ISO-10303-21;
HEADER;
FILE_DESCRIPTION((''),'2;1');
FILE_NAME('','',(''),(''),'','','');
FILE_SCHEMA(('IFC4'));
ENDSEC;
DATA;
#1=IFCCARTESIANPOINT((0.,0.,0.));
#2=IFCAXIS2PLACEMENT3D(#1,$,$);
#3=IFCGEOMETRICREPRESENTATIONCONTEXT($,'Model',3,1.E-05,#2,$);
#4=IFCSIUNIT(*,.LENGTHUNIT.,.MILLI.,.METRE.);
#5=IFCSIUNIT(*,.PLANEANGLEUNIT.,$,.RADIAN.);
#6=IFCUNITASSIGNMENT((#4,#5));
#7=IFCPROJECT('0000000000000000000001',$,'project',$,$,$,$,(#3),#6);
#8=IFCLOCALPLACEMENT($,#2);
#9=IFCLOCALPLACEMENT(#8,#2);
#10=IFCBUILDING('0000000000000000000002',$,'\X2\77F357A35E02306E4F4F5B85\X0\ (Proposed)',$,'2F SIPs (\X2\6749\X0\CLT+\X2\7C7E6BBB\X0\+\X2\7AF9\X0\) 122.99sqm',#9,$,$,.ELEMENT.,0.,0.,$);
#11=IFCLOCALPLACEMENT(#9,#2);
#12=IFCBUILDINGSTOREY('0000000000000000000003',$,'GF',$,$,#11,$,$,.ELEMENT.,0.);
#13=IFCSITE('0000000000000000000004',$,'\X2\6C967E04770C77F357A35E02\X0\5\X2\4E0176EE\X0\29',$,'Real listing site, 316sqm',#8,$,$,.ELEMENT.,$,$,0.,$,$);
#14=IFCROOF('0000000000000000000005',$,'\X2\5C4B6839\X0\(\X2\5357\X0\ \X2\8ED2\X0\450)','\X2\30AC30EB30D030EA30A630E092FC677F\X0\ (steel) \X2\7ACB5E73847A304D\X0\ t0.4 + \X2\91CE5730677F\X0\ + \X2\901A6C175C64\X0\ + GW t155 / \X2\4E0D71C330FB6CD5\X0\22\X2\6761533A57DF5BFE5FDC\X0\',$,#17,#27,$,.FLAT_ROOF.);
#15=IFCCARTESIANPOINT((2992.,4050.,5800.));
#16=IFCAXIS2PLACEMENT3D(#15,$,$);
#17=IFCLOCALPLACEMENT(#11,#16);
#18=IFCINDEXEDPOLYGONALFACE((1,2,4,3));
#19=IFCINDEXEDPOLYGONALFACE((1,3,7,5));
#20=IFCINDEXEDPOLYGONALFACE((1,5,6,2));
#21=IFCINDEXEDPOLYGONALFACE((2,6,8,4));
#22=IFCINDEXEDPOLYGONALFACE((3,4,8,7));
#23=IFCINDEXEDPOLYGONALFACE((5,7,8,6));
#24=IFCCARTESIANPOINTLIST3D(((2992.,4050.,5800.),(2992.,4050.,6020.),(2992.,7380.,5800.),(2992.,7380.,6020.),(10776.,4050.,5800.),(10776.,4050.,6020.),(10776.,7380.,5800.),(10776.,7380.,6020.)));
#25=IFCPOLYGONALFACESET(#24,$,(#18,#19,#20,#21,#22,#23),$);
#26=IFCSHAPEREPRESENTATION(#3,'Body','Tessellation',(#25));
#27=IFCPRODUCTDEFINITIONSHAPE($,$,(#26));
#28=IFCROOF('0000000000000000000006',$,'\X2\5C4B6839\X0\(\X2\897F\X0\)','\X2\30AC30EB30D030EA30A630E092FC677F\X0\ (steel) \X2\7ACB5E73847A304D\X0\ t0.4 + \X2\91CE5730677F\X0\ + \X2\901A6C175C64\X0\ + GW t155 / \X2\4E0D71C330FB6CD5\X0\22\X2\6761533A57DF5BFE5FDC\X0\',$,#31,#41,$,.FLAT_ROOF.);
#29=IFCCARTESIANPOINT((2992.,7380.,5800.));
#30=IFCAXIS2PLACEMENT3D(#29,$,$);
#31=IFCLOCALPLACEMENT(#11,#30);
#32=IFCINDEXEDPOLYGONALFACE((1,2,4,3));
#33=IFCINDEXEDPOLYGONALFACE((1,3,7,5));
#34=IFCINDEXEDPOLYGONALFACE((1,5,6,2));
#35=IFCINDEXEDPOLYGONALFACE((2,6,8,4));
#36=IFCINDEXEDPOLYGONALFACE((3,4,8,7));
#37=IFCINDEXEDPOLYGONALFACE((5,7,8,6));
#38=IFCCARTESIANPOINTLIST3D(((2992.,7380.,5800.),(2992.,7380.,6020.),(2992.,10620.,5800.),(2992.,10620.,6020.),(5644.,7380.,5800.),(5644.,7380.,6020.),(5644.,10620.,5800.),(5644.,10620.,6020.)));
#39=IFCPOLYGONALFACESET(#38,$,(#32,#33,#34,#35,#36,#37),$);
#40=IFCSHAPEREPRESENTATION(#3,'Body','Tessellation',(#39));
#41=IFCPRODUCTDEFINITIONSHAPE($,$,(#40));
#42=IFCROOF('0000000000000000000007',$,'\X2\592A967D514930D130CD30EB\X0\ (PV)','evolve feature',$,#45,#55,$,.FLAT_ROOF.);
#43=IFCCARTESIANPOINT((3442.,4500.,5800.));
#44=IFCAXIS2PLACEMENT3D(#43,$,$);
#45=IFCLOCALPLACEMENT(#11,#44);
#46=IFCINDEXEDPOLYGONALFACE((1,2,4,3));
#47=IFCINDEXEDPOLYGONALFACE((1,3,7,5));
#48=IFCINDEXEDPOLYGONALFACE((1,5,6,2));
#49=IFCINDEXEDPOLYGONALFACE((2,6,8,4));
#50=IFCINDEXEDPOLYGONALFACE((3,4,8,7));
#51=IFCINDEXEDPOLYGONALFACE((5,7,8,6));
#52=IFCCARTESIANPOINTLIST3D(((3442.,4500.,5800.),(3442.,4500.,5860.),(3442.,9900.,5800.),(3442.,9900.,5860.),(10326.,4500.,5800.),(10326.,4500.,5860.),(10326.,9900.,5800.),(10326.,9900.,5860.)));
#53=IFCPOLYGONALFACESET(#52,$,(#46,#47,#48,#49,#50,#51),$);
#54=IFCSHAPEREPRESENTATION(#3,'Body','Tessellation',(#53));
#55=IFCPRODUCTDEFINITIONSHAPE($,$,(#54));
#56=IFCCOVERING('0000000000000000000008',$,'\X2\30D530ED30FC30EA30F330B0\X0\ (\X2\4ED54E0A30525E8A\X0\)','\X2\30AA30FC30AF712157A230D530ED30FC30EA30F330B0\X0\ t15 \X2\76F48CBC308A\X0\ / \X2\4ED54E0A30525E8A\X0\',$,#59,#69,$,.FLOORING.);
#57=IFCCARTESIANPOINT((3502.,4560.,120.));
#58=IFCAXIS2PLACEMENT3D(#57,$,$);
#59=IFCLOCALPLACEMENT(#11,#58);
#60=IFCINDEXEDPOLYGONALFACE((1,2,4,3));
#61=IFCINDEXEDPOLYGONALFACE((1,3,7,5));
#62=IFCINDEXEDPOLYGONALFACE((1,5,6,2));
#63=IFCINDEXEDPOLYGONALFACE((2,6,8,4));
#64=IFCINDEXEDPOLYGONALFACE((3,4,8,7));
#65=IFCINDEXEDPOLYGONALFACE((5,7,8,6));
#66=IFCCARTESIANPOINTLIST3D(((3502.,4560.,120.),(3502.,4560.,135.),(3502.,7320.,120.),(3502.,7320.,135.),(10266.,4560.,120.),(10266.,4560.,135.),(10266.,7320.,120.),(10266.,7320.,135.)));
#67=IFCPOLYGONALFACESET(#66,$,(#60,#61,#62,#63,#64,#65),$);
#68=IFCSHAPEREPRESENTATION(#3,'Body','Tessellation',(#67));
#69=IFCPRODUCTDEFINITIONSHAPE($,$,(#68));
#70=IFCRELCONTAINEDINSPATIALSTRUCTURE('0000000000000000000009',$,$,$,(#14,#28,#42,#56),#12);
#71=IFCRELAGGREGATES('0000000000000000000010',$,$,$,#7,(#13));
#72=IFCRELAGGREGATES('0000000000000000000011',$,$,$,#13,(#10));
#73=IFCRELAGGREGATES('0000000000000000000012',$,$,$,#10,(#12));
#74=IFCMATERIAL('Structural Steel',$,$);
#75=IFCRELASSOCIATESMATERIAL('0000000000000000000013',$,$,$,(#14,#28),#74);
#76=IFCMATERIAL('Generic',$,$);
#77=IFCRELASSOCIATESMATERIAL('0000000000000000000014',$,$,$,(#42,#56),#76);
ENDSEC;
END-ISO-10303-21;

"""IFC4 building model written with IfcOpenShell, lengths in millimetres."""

from ifc_helpers import new_model, si_unit, frame, frame_2d, origin, place, context, project, spatial, rectangle, extrude, material, element, save


model = new_model("IFC4")

# Units and contexts
model_context = context("Model", 3, precision=1e-05, world=origin())
ifc_project = project(units=[si_unit("LENGTHUNIT", "METRE", prefix="MILLI"), si_unit("PLANEANGLEUNIT", "RADIAN")], contexts=[model_context])

# Site, building, storey
site_placement = place(None, origin())
site = spatial("IfcSite", under=ifc_project, at=site_placement, Name="沖縄県石垣市5丁目29", ObjectType="Real listing site, 316sqm", CompositionType="ELEMENT", RefElevation=0.0)
building_placement = place(site_placement, origin())
building = spatial("IfcBuilding", under=site, at=building_placement, Name="石垣市の住宅 (Proposed)", ObjectType="2F SIPs (杉CLT+籾殻+竹) 122.99sqm", CompositionType="ELEMENT", ElevationOfRefHeight=0.0, ElevationOfTerrain=0.0)
storey_placement = place(building_placement, origin())
storey = spatial("IfcBuildingStorey", under=building, at=storey_placement, Name="GF", CompositionType="ELEMENT", Elevation=0.0)

# Shared definitions
ifc_material_1 = material(Name="Generic")

# Roofs
ifc_material_2 = material(Name="Structural Steel")
roof_1_placement = place(storey_placement, frame((2992.0, 4050.0, 5800.0)))
element("IfcRoof", 1, at=roof_1_placement, inside=storey, material=ifc_material_2, Name="屋根(南 軒450)", Description="ガルバリウム鋼板 (steel) 立平葺き t0.4 + 野地板 + 通気層 + GW t155 / 不燃・法22条区域対応", PredefinedType="FLAT_ROOF", context=model_context, shape_type="SweptSolid", body=[
    extrude(rectangle(XDim=7784.0, YDim=3330.0, at=frame_2d((3892.0, 1665.0))), frame((2992.0, 4050.0, 5800.0)), (0.0, 0.0, 1.0), 220.0),
])
roof_2_placement = place(storey_placement, frame((2992.0, 7380.0, 5800.0)))
element("IfcRoof", 2, at=roof_2_placement, inside=storey, material=ifc_material_2, Name="屋根(西)", Description="ガルバリウム鋼板 (steel) 立平葺き t0.4 + 野地板 + 通気層 + GW t155 / 不燃・法22条区域対応", PredefinedType="FLAT_ROOF", context=model_context, shape_type="SweptSolid", body=[
    extrude(rectangle(XDim=2652.0, YDim=3240.0, at=frame_2d((1326.0, 1620.0))), frame((2992.0, 7380.0, 5800.0)), (0.0, 0.0, 1.0), 220.0),
])
roof_3_placement = place(storey_placement, frame((3442.0, 4500.0, 5800.0)))
element("IfcRoof", 3, at=roof_3_placement, inside=storey, material=ifc_material_1, Name="太陽光パネル (PV)", Description="evolve feature", PredefinedType="FLAT_ROOF", context=model_context, shape_type="SweptSolid", body=[
    extrude(rectangle(XDim=6884.0, YDim=5400.0, at=frame_2d((3442.0, 2700.0))), frame((3442.0, 4500.0, 5800.0)), (0.0, 0.0, 1.0), 60.0),
])

# Covering
covering_placement = place(storey_placement, frame((3502.0, 4560.0, 120.0)))
element("IfcCovering", 4, at=covering_placement, inside=storey, material=ifc_material_1, Name="フローリング (仕上げ床)", Description="オーク無垢フローリング t15 直貼り / 仕上げ床", PredefinedType="FLOORING", context=model_context, shape_type="SweptSolid", body=[
    extrude(rectangle(XDim=6764.0, YDim=2760.0, at=frame_2d((3382.0, 1380.0))), frame((3502.0, 4560.0, 120.0)), (0.0, 0.0, 1.0), 15.0),
])

save(model, "model.ifc")
